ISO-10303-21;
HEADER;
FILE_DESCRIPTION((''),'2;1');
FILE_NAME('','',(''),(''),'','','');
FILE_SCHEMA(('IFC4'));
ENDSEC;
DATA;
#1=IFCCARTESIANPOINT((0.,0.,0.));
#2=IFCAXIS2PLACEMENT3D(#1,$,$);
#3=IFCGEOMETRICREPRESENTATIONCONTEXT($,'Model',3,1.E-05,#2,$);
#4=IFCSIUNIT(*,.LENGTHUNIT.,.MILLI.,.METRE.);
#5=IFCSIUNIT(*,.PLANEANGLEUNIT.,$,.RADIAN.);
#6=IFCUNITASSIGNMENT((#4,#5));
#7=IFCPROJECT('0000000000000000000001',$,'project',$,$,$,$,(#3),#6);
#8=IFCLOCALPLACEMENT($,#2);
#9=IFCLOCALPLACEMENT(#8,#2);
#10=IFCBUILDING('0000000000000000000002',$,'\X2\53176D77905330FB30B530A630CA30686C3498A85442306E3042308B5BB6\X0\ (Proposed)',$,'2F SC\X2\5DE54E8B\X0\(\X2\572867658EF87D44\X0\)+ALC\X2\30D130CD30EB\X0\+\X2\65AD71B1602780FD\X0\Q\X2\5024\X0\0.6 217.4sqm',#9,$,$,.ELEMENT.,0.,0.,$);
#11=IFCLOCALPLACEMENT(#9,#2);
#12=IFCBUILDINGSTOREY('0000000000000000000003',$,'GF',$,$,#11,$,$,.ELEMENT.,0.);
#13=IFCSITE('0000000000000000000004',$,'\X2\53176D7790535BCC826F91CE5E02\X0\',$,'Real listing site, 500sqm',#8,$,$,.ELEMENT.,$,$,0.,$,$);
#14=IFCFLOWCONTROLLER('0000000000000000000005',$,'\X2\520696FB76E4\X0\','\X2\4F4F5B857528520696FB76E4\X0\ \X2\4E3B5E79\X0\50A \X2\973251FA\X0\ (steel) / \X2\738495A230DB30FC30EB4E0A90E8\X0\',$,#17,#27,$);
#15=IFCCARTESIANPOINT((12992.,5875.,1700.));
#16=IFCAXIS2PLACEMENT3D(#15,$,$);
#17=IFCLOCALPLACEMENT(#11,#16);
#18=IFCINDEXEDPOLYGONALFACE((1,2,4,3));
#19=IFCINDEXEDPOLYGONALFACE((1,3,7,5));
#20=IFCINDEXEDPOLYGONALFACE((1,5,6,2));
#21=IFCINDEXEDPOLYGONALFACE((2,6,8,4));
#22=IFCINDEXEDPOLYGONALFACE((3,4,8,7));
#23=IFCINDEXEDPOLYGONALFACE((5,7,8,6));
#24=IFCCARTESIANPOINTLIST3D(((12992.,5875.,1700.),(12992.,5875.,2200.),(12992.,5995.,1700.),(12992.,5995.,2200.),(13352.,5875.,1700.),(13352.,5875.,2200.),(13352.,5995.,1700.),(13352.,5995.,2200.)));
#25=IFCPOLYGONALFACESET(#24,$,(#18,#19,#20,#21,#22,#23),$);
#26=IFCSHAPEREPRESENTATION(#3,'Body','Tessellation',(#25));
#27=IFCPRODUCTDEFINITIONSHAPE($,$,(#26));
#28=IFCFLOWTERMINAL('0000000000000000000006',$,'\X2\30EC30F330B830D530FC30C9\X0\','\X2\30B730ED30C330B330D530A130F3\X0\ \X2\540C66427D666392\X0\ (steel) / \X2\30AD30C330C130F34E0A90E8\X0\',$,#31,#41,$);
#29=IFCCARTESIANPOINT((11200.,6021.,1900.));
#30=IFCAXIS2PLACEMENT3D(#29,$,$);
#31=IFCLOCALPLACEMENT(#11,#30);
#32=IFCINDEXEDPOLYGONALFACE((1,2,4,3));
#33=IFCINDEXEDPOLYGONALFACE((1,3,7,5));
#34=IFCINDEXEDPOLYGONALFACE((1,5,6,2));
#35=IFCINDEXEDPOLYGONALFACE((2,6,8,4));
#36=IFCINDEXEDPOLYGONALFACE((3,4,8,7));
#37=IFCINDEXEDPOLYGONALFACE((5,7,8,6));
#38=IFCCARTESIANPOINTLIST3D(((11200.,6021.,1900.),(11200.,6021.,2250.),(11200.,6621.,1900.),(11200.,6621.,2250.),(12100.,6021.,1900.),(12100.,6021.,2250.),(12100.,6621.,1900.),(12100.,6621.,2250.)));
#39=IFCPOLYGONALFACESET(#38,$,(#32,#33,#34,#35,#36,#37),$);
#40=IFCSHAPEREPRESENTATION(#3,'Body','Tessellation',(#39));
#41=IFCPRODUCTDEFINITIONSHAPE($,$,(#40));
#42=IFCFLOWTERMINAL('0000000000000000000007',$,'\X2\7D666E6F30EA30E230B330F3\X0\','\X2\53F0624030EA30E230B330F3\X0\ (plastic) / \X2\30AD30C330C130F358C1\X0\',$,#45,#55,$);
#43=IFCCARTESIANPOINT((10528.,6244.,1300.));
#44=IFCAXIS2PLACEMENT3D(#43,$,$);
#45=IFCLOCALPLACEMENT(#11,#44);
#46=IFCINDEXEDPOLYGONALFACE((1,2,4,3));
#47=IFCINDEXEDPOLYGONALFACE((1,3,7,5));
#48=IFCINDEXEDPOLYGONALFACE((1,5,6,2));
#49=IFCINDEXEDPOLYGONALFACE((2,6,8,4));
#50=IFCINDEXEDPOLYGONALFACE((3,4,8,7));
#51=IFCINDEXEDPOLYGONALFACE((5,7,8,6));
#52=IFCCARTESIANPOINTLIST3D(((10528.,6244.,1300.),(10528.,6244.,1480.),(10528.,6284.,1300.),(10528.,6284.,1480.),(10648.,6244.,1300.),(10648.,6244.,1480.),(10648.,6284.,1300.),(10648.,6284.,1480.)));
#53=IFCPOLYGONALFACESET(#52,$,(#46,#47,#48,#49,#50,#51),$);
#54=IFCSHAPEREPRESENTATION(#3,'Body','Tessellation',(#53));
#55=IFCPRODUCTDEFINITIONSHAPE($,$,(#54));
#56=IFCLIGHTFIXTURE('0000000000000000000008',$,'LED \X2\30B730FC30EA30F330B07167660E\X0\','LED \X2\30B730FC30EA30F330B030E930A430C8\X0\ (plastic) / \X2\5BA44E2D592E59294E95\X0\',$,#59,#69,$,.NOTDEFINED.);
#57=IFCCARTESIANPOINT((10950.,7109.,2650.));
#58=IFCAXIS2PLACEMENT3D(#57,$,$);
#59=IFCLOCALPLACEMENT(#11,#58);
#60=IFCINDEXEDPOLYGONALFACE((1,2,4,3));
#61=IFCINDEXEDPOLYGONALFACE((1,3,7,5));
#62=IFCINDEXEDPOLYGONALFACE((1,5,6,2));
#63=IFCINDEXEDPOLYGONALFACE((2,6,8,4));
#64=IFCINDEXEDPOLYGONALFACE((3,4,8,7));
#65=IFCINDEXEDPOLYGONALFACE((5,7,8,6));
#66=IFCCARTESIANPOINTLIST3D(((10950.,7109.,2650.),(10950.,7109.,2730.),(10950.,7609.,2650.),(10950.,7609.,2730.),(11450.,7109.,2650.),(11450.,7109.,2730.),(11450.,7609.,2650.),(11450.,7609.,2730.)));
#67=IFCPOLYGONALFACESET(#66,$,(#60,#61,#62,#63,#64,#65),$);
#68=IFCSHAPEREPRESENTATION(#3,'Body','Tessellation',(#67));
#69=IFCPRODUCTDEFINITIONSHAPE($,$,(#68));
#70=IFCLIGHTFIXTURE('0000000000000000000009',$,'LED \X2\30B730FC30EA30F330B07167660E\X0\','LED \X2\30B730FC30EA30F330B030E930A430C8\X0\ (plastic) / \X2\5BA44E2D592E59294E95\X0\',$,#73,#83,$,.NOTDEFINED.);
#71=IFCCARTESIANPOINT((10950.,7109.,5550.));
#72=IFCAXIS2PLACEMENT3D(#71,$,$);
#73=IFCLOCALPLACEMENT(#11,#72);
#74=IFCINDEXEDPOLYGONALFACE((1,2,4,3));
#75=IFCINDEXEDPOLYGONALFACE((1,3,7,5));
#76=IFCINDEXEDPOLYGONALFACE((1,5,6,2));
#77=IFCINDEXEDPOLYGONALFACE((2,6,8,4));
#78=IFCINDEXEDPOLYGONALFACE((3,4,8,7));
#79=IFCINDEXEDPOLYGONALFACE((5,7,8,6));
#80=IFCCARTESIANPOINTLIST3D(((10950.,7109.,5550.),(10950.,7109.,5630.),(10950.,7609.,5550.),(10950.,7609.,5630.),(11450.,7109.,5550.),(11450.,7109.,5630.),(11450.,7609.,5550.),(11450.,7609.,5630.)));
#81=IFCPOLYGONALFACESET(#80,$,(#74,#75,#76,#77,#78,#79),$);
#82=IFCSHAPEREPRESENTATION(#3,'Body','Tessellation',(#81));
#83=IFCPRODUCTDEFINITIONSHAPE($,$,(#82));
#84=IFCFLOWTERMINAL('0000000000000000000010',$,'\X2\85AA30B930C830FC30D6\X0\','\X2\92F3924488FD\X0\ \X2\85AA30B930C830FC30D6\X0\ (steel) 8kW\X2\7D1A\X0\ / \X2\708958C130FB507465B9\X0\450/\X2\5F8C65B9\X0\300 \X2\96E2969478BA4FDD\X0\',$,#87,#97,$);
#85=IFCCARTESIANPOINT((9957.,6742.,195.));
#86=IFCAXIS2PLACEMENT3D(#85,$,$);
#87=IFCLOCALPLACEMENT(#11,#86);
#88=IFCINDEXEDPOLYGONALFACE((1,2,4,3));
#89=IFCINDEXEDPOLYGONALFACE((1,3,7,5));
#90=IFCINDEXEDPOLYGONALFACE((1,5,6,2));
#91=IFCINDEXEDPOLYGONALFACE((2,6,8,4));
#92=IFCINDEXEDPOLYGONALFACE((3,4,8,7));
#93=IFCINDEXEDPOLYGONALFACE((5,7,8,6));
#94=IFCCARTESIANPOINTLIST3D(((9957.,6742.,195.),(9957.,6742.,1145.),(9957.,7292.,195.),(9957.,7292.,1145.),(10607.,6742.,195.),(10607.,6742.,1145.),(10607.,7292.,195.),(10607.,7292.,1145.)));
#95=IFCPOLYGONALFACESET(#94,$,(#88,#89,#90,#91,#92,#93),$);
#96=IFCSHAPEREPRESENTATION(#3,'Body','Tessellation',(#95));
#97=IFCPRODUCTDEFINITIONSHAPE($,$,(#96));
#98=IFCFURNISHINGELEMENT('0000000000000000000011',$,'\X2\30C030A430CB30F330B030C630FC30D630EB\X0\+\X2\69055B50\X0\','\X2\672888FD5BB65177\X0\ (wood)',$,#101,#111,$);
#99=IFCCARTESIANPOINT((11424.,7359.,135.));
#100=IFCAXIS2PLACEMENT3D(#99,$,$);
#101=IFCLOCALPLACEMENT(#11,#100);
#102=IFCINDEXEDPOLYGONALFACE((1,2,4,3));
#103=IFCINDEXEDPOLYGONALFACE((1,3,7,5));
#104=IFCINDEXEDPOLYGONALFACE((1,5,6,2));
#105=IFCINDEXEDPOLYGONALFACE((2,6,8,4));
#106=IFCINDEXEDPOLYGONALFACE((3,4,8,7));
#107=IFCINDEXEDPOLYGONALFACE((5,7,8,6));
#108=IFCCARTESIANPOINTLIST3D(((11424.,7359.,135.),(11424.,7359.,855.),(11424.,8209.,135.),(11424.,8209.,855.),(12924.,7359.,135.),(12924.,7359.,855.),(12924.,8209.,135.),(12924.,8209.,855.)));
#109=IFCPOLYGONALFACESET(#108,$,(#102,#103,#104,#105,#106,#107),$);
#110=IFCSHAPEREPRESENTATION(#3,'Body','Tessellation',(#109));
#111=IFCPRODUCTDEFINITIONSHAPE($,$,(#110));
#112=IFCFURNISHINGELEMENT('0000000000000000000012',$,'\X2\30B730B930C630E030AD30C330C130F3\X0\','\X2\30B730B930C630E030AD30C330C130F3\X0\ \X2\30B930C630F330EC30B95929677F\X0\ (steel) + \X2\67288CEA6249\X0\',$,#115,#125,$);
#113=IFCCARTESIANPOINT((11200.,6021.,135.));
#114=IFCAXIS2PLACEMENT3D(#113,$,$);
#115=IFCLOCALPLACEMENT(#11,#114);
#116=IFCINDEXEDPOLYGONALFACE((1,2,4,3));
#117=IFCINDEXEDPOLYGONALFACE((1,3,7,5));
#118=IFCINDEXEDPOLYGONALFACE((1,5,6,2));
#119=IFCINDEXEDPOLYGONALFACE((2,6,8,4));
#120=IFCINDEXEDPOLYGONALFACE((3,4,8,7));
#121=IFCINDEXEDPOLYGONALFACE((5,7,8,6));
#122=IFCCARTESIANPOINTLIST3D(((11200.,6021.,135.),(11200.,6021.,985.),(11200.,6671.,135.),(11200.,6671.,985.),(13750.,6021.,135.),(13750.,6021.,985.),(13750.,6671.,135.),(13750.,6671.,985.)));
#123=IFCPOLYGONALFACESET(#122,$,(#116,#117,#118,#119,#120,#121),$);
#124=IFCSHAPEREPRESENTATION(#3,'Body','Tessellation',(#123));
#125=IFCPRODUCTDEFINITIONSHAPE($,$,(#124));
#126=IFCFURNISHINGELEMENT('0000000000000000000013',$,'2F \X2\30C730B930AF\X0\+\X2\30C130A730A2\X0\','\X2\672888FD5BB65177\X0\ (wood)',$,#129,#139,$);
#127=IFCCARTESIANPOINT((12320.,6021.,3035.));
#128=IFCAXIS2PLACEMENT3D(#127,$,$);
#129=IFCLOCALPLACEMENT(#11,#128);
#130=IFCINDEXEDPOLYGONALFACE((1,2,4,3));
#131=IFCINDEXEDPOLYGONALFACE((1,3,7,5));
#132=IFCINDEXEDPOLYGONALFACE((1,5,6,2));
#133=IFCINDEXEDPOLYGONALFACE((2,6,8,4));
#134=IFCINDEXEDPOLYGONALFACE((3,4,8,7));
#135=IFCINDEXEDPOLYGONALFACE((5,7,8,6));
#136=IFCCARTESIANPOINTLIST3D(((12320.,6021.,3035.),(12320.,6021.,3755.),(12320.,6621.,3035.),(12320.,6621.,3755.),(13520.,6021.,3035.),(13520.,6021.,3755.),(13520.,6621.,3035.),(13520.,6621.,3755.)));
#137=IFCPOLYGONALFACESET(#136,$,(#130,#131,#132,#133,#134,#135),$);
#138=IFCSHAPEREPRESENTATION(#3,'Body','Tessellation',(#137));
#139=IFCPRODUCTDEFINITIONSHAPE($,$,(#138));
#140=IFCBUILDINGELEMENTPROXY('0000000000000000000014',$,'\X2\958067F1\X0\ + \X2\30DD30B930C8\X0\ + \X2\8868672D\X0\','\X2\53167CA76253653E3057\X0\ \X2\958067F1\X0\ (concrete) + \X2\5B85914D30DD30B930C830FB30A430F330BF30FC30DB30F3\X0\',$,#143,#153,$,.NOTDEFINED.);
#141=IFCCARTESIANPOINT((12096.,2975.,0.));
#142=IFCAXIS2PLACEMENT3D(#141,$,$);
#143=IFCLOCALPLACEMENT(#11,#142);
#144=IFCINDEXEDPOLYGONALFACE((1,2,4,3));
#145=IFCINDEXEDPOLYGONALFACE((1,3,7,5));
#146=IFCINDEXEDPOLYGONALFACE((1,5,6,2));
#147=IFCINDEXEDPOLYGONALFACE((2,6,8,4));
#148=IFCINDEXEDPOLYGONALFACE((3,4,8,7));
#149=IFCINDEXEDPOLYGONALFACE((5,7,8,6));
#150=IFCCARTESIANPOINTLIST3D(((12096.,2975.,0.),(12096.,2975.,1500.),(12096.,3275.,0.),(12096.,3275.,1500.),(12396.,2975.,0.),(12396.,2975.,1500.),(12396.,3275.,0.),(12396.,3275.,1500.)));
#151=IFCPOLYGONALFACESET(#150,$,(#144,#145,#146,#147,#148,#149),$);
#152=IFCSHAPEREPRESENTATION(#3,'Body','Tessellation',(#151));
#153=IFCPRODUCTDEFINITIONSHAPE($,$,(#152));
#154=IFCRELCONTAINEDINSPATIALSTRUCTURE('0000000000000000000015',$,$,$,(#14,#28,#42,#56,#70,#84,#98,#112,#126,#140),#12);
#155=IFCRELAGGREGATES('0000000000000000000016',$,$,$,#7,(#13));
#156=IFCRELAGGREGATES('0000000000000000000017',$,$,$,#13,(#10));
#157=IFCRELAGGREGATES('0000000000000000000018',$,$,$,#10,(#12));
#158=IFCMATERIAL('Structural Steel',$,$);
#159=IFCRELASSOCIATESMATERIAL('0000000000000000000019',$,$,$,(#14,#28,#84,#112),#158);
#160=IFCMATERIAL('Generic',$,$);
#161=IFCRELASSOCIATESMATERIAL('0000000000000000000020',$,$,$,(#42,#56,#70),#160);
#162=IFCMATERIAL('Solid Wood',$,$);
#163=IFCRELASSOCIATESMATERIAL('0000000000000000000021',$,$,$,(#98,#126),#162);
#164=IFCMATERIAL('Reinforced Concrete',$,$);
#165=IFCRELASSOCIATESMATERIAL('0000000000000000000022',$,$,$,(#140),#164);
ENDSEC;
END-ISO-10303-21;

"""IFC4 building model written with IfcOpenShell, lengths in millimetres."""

from ifc_helpers import new_model, si_unit, frame, frame_2d, origin, place, context, project, spatial, rectangle, extrude, material, element, save


model = new_model("IFC4")

# Units and contexts
model_context = context("Model", 3, precision=1e-05, world=origin())
ifc_project = project(units=[si_unit("LENGTHUNIT", "METRE", prefix="MILLI"), si_unit("PLANEANGLEUNIT", "RADIAN")], contexts=[model_context])

# Site, building, storey
site_placement = place(None, origin())
site = spatial("IfcSite", under=ifc_project, at=site_placement, Name="北海道富良野市", ObjectType="Real listing site, 500sqm", CompositionType="ELEMENT", RefElevation=0.0)
building_placement = place(site_placement, origin())
building = spatial("IfcBuilding", under=site, at=building_placement, Name="北海道・サウナと水風呂のある家 (Proposed)", ObjectType="2F SC工事(在来軸組)+ALCパネル+断熱性能Q値0.6 217.4sqm", CompositionType="ELEMENT", ElevationOfRefHeight=0.0, ElevationOfTerrain=0.0)
storey_placement = place(building_placement, origin())
storey = spatial("IfcBuildingStorey", under=building, at=storey_placement, Name="GF", CompositionType="ELEMENT", Elevation=0.0)

# Shared definitions
ifc_material_1 = material(Name="Solid Wood")

# Shared definitions
ifc_material_2 = material(Name="Structural Steel")

# Shared definitions
ifc_material_3 = material(Name="Reinforced Concrete")

# Flow controller
flow_controller_placement = place(storey_placement, frame((12992.0, 5875.0, 1700.0)))
element("IfcFlowController", 1, at=flow_controller_placement, inside=storey, material=ifc_material_2, Name="分電盤", Description="住宅用分電盤 主幹50A 露出 (steel) / 玄関ホール上部", context=model_context, shape_type="SweptSolid", body=[
    extrude(rectangle(XDim=360.0, YDim=120.0, at=frame_2d((180.0, 60.0))), frame((12992.0, 5875.0, 1700.0)), (0.0, 0.0, 1.0), 500.0),
])

# Flow terminals
flow_terminal_1_placement = place(storey_placement, frame((11200.0, 6021.0, 1900.0)))
element("IfcFlowTerminal", 2, at=flow_terminal_1_placement, inside=storey, material=ifc_material_2, Name="レンジフード", Description="シロッコファン 同時給排 (steel) / キッチン上部", context=model_context, shape_type="SweptSolid", body=[
    extrude(rectangle(XDim=900.0, YDim=600.0, at=frame_2d((450.0, 300.0))), frame((11200.0, 6021.0, 1900.0)), (0.0, 0.0, 1.0), 350.0),
])
ifc_material_4 = material(Name="Generic")
flow_terminal_2_placement = place(storey_placement, frame((10528.0, 6244.0, 1300.0)))
element("IfcFlowTerminal", 3, at=flow_terminal_2_placement, inside=storey, material=ifc_material_4, Name="給湯リモコン", Description="台所リモコン (plastic) / キッチン壁", context=model_context, shape_type="SweptSolid", body=[
    extrude(rectangle(XDim=120.0, YDim=40.0, at=frame_2d((60.0, 20.0))), frame((10528.0, 6244.0, 1300.0)), (0.0, 0.0, 1.0), 180.0),
])

# Light fixtures
light_fixture_1_placement = place(storey_placement, frame((10950.0, 7109.0, 2650.0)))
element("IfcLightFixture", 4, at=light_fixture_1_placement, inside=storey, material=ifc_material_4, Name="LED シーリング照明", Description="LED シーリングライト (plastic) / 室中央天井", PredefinedType="NOTDEFINED", context=model_context, shape_type="SweptSolid", body=[
    extrude(rectangle(XDim=500.0, YDim=500.0, at=frame_2d((250.0, 250.0))), frame((10950.0, 7109.0, 2650.0)), (0.0, 0.0, 1.0), 80.0),
])
light_fixture_2_placement = place(storey_placement, frame((10950.0, 7109.0, 5550.0)))
element("IfcLightFixture", 5, at=light_fixture_2_placement, inside=storey, material=ifc_material_4, Name="LED シーリング照明", Description="LED シーリングライト (plastic) / 室中央天井", PredefinedType="NOTDEFINED", context=model_context, shape_type="SweptSolid", body=[
    extrude(rectangle(XDim=500.0, YDim=500.0, at=frame_2d((250.0, 250.0))), frame((10950.0, 7109.0, 5550.0)), (0.0, 0.0, 1.0), 80.0),
])

# Flow terminal
flow_terminal_3_placement = place(storey_placement, frame((9957.0, 6742.0, 195.0)))
element("IfcFlowTerminal", 6, at=flow_terminal_3_placement, inside=storey, material=ifc_material_2, Name="薪ストーブ", Description="鋳鉄製 薪ストーブ (steel) 8kW級 / 炉壁・側方450/後方300 離隔確保", context=model_context, shape_type="SweptSolid", body=[
    extrude(rectangle(XDim=650.0, YDim=550.0, at=frame_2d((325.0, 275.0))), frame((9957.0, 6742.0, 195.0)), (0.0, 0.0, 1.0), 950.0),
])

# Furnishing elements
furnishing_1_placement = place(storey_placement, frame((11424.0, 7359.0, 135.0)))
element("IfcFurnishingElement", 7, at=furnishing_1_placement, inside=storey, material=ifc_material_1, Name="ダイニングテーブル+椅子", Description="木製家具 (wood)", context=model_context, shape_type="SweptSolid", body=[
    extrude(rectangle(XDim=1500.0, YDim=850.0, at=frame_2d((750.0, 425.0))), frame((11424.0, 7359.0, 135.0)), (0.0, 0.0, 1.0), 720.0),
])
furnishing_2_placement = place(storey_placement, frame((11200.0, 6021.0, 135.0)))
element("IfcFurnishingElement", 8, at=furnishing_2_placement, inside=storey, material=ifc_material_2, Name="システムキッチン", Description="システムキッチン ステンレス天板 (steel) + 木質扉", context=model_context, shape_type="SweptSolid", body=[
    extrude(rectangle(XDim=2550.0, YDim=650.0, at=frame_2d((1275.0, 325.0))), frame((11200.0, 6021.0, 135.0)), (0.0, 0.0, 1.0), 850.0),
])
furnishing_3_placement = place(storey_placement, frame((12320.0, 6021.0, 3035.0)))
element("IfcFurnishingElement", 9, at=furnishing_3_placement, inside=storey, material=ifc_material_1, Name="2F デスク+チェア", Description="木製家具 (wood)", context=model_context, shape_type="SweptSolid", body=[
    extrude(rectangle(XDim=1200.0, YDim=600.0, at=frame_2d((600.0, 300.0))), frame((12320.0, 6021.0, 3035.0)), (0.0, 0.0, 1.0), 720.0),
])

# Building element proxy
proxy_placement = place(storey_placement, frame((12096.0, 2975.0, 0.0)))
element("IfcBuildingElementProxy", 10, at=proxy_placement, inside=storey, material=ifc_material_3, Name="門柱 + ポスト + 表札", Description="化粧打放し 門柱 (concrete) + 宅配ポスト・インターホン", PredefinedType="NOTDEFINED", context=model_context, shape_type="SweptSolid", body=[
    extrude(rectangle(XDim=300.0, YDim=300.0, at=frame_2d((150.0, 150.0))), frame((12096.0, 2975.0, 0.0)), (0.0, 0.0, 1.0), 1500.0),
])

save(model, "model.ifc")
